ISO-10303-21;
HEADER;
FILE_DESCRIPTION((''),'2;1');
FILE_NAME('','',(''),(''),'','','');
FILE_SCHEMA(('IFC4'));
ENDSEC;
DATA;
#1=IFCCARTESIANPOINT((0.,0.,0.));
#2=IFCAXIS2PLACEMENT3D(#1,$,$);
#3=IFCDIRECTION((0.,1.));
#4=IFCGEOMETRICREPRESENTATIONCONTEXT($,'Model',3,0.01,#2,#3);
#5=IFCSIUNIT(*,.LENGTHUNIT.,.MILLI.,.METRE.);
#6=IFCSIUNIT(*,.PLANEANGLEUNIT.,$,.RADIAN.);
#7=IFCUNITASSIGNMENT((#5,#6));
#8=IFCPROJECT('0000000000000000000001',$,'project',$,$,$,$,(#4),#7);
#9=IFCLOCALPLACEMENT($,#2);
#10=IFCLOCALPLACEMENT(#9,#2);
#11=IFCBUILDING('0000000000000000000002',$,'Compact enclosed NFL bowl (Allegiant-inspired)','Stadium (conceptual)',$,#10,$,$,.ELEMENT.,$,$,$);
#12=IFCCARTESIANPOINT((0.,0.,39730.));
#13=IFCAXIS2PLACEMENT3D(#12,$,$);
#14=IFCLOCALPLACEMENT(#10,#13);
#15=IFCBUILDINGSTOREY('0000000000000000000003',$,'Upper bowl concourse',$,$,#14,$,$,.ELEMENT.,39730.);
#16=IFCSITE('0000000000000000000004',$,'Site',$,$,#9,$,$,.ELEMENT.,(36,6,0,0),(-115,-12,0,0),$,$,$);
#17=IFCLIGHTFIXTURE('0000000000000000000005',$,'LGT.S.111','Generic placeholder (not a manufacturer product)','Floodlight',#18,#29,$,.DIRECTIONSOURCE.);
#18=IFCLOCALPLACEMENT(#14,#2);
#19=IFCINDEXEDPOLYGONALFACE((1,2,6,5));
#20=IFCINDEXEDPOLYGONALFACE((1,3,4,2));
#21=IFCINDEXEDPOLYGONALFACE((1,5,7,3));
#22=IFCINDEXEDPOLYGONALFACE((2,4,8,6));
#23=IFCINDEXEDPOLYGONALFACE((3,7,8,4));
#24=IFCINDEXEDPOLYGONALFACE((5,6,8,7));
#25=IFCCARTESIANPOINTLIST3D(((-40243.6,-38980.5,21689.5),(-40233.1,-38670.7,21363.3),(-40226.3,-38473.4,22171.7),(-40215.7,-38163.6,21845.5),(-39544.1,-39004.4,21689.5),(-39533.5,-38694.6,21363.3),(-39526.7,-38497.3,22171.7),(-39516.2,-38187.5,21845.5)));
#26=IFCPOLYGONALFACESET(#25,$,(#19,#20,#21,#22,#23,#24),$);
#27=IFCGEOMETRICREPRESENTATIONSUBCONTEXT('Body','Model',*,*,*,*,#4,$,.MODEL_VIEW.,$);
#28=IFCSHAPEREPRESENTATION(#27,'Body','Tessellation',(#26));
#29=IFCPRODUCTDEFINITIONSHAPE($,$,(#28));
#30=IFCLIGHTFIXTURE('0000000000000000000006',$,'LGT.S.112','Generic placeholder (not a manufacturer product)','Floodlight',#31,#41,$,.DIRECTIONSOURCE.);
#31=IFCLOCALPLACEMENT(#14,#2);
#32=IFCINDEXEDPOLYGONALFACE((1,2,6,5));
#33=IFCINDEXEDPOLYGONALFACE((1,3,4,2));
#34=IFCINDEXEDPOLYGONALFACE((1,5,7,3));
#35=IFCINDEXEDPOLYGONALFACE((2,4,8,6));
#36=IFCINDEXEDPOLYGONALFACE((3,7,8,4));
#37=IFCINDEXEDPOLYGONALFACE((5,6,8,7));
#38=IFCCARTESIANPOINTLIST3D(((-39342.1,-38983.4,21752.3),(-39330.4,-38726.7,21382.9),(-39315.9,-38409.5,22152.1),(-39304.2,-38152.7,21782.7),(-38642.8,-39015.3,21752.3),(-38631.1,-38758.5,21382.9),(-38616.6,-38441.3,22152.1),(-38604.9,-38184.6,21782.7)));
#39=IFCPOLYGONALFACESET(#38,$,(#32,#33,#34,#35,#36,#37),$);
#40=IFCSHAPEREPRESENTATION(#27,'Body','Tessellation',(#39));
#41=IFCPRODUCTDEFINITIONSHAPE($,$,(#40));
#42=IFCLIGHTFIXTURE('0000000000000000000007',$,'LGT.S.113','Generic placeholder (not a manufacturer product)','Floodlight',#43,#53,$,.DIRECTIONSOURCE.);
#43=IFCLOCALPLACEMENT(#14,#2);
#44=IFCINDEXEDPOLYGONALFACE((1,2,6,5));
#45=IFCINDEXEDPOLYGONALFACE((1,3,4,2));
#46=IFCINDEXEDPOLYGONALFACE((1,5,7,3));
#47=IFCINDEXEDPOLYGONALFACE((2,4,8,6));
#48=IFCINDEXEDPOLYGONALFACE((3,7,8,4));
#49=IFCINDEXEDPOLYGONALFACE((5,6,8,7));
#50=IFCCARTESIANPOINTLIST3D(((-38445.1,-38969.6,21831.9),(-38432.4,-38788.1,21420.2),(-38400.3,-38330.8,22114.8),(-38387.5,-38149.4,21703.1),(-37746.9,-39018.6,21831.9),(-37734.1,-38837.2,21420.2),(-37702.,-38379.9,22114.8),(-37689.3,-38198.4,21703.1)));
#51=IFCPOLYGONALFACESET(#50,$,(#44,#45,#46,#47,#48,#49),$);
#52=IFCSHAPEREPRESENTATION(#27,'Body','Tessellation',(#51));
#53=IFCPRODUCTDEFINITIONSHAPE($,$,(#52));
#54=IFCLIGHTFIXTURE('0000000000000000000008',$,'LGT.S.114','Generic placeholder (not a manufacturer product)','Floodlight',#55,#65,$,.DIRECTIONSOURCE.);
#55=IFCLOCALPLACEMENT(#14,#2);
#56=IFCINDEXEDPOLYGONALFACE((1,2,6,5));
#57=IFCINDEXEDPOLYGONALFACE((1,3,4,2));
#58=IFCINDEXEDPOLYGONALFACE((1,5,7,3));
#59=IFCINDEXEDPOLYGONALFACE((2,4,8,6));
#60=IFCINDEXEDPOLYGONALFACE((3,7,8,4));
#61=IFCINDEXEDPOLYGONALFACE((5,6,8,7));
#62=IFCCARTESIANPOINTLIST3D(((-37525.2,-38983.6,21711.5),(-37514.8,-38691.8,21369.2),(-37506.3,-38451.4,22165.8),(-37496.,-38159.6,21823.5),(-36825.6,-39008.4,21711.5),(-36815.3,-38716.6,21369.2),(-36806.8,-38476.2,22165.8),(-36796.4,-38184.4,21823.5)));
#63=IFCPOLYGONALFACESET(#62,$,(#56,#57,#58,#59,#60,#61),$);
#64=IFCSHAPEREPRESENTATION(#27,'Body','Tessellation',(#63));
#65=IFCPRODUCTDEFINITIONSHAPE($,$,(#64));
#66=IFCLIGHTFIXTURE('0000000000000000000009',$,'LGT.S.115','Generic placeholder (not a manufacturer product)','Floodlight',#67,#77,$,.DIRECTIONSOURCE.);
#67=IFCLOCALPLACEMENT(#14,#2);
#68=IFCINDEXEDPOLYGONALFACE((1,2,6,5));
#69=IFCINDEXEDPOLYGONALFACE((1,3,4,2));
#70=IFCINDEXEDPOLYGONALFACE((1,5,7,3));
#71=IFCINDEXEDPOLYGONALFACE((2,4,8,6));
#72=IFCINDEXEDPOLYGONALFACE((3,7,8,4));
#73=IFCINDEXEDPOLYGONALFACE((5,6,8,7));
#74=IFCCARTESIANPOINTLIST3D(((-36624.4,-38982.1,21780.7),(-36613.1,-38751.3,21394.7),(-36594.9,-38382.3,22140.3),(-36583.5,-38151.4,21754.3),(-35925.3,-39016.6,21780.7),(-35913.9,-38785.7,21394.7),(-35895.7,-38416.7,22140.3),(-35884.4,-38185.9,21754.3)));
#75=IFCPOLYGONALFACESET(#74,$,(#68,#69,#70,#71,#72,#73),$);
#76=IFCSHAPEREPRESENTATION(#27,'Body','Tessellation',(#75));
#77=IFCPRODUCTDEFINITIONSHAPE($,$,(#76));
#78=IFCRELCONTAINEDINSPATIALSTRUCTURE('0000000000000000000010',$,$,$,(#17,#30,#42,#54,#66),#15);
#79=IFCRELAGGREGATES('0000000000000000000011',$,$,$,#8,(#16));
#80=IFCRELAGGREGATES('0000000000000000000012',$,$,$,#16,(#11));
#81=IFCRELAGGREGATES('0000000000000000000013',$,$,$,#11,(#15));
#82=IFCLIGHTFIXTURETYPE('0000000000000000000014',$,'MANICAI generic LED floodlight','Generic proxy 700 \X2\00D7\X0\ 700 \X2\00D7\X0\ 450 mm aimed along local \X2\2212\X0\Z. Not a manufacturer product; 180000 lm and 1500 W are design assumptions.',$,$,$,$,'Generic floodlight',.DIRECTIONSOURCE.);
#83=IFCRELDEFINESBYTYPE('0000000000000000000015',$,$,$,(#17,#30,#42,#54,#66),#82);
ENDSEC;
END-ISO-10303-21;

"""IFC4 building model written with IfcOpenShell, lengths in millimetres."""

from ifc_helpers import new_model, si_unit, direction, frame, origin, place, context, subcontext, project, spatial, rectangle, extrude, source, transform, mapped, type_object, type_shapes, element, save


model = new_model("IFC4")

# Units and contexts
model_context = context("Model", 3, precision=0.01, world=origin(), true_north=direction((0.0, 1.0)))
body_context = subcontext(model_context, "Body", "Model", "MODEL_VIEW")
ifc_project = project(units=[si_unit("LENGTHUNIT", "METRE", prefix="MILLI"), si_unit("PLANEANGLEUNIT", "RADIAN")], contexts=[model_context])

# Site, building, storey
site_placement = place(None, origin())
site = spatial("IfcSite", under=ifc_project, at=site_placement, Name="Site", CompositionType="ELEMENT", RefLatitude=(36, 6, 0, 0), RefLongitude=(-115, -12, 0, 0))
building_placement = place(site_placement, origin())
building = spatial("IfcBuilding", under=site, at=building_placement, Name="Compact enclosed NFL bowl (Allegiant-inspired)", Description="Stadium (conceptual)", CompositionType="ELEMENT")
storey_placement = place(building_placement, frame((0.0, 0.0, 39730.0)))
storey = spatial("IfcBuildingStorey", under=building, at=storey_placement, Name="Upper bowl concourse", CompositionType="ELEMENT", Elevation=39730.0)

# Light fixtures
light_fixture_type = type_object("IfcLightFixtureType", Name="MANICAI generic LED floodlight", Description="Generic proxy 700 × 700 × 450 mm aimed along local −Z. Not a manufacturer product; 180000 lm and 1500 W are design assumptions.", ElementType="Generic floodlight", PredefinedType="DIRECTIONSOURCE")
shared_shape = source(origin(), body_context, "Body", "SweptSolid", [
    extrude(rectangle(XDim=700.0, YDim=700.0), frame((0.0, 0.0, -225.0)), (0.0, 0.0, 1.0), 450.0),
])
type_shapes(light_fixture_type, [shared_shape])
for number, where, z_axis, x_axis, name in (
    (1, (-39879.9, -38584.0, 21767.5), (-0.023505, -0.688422, 0.72493), (0.999418, -0.034124, 0.0), "LGT.S.111"),
    (2, (-38973.5, -38584.0, 21767.5), (-0.026009, -0.570622, 0.820801), (0.998963, -0.045532, 0.0), "LGT.S.112"),
    (3, (-38067.2, -38584.0, 21767.5), (-0.02831, -0.403162, 0.914691), (0.997544, -0.070047, 0.0), "LGT.S.113"),
    (4, (-37160.8, -38584.0, 21767.5), (-0.022987, -0.64856, 0.760816), (0.999372, -0.035421, 0.0), "LGT.S.114"),
    (5, (-36254.4, -38584.0, 21767.5), (-0.02529, -0.513078, 0.857969), (0.998787, -0.049231, 0.0), "LGT.S.115"),
):
    element("IfcLightFixture", number, at=place(storey_placement, frame(where, z_axis=z_axis, x_axis=x_axis)), inside=storey, type_object=light_fixture_type, Name=name, Description="Generic placeholder (not a manufacturer product)", ObjectType="Floodlight", PredefinedType="DIRECTIONSOURCE", context=body_context, shape_type="MappedRepresentation", body=[
        mapped(shared_shape, transform((0.0, 0.0, 0.0))),
    ])

save(model, "model.ifc")
